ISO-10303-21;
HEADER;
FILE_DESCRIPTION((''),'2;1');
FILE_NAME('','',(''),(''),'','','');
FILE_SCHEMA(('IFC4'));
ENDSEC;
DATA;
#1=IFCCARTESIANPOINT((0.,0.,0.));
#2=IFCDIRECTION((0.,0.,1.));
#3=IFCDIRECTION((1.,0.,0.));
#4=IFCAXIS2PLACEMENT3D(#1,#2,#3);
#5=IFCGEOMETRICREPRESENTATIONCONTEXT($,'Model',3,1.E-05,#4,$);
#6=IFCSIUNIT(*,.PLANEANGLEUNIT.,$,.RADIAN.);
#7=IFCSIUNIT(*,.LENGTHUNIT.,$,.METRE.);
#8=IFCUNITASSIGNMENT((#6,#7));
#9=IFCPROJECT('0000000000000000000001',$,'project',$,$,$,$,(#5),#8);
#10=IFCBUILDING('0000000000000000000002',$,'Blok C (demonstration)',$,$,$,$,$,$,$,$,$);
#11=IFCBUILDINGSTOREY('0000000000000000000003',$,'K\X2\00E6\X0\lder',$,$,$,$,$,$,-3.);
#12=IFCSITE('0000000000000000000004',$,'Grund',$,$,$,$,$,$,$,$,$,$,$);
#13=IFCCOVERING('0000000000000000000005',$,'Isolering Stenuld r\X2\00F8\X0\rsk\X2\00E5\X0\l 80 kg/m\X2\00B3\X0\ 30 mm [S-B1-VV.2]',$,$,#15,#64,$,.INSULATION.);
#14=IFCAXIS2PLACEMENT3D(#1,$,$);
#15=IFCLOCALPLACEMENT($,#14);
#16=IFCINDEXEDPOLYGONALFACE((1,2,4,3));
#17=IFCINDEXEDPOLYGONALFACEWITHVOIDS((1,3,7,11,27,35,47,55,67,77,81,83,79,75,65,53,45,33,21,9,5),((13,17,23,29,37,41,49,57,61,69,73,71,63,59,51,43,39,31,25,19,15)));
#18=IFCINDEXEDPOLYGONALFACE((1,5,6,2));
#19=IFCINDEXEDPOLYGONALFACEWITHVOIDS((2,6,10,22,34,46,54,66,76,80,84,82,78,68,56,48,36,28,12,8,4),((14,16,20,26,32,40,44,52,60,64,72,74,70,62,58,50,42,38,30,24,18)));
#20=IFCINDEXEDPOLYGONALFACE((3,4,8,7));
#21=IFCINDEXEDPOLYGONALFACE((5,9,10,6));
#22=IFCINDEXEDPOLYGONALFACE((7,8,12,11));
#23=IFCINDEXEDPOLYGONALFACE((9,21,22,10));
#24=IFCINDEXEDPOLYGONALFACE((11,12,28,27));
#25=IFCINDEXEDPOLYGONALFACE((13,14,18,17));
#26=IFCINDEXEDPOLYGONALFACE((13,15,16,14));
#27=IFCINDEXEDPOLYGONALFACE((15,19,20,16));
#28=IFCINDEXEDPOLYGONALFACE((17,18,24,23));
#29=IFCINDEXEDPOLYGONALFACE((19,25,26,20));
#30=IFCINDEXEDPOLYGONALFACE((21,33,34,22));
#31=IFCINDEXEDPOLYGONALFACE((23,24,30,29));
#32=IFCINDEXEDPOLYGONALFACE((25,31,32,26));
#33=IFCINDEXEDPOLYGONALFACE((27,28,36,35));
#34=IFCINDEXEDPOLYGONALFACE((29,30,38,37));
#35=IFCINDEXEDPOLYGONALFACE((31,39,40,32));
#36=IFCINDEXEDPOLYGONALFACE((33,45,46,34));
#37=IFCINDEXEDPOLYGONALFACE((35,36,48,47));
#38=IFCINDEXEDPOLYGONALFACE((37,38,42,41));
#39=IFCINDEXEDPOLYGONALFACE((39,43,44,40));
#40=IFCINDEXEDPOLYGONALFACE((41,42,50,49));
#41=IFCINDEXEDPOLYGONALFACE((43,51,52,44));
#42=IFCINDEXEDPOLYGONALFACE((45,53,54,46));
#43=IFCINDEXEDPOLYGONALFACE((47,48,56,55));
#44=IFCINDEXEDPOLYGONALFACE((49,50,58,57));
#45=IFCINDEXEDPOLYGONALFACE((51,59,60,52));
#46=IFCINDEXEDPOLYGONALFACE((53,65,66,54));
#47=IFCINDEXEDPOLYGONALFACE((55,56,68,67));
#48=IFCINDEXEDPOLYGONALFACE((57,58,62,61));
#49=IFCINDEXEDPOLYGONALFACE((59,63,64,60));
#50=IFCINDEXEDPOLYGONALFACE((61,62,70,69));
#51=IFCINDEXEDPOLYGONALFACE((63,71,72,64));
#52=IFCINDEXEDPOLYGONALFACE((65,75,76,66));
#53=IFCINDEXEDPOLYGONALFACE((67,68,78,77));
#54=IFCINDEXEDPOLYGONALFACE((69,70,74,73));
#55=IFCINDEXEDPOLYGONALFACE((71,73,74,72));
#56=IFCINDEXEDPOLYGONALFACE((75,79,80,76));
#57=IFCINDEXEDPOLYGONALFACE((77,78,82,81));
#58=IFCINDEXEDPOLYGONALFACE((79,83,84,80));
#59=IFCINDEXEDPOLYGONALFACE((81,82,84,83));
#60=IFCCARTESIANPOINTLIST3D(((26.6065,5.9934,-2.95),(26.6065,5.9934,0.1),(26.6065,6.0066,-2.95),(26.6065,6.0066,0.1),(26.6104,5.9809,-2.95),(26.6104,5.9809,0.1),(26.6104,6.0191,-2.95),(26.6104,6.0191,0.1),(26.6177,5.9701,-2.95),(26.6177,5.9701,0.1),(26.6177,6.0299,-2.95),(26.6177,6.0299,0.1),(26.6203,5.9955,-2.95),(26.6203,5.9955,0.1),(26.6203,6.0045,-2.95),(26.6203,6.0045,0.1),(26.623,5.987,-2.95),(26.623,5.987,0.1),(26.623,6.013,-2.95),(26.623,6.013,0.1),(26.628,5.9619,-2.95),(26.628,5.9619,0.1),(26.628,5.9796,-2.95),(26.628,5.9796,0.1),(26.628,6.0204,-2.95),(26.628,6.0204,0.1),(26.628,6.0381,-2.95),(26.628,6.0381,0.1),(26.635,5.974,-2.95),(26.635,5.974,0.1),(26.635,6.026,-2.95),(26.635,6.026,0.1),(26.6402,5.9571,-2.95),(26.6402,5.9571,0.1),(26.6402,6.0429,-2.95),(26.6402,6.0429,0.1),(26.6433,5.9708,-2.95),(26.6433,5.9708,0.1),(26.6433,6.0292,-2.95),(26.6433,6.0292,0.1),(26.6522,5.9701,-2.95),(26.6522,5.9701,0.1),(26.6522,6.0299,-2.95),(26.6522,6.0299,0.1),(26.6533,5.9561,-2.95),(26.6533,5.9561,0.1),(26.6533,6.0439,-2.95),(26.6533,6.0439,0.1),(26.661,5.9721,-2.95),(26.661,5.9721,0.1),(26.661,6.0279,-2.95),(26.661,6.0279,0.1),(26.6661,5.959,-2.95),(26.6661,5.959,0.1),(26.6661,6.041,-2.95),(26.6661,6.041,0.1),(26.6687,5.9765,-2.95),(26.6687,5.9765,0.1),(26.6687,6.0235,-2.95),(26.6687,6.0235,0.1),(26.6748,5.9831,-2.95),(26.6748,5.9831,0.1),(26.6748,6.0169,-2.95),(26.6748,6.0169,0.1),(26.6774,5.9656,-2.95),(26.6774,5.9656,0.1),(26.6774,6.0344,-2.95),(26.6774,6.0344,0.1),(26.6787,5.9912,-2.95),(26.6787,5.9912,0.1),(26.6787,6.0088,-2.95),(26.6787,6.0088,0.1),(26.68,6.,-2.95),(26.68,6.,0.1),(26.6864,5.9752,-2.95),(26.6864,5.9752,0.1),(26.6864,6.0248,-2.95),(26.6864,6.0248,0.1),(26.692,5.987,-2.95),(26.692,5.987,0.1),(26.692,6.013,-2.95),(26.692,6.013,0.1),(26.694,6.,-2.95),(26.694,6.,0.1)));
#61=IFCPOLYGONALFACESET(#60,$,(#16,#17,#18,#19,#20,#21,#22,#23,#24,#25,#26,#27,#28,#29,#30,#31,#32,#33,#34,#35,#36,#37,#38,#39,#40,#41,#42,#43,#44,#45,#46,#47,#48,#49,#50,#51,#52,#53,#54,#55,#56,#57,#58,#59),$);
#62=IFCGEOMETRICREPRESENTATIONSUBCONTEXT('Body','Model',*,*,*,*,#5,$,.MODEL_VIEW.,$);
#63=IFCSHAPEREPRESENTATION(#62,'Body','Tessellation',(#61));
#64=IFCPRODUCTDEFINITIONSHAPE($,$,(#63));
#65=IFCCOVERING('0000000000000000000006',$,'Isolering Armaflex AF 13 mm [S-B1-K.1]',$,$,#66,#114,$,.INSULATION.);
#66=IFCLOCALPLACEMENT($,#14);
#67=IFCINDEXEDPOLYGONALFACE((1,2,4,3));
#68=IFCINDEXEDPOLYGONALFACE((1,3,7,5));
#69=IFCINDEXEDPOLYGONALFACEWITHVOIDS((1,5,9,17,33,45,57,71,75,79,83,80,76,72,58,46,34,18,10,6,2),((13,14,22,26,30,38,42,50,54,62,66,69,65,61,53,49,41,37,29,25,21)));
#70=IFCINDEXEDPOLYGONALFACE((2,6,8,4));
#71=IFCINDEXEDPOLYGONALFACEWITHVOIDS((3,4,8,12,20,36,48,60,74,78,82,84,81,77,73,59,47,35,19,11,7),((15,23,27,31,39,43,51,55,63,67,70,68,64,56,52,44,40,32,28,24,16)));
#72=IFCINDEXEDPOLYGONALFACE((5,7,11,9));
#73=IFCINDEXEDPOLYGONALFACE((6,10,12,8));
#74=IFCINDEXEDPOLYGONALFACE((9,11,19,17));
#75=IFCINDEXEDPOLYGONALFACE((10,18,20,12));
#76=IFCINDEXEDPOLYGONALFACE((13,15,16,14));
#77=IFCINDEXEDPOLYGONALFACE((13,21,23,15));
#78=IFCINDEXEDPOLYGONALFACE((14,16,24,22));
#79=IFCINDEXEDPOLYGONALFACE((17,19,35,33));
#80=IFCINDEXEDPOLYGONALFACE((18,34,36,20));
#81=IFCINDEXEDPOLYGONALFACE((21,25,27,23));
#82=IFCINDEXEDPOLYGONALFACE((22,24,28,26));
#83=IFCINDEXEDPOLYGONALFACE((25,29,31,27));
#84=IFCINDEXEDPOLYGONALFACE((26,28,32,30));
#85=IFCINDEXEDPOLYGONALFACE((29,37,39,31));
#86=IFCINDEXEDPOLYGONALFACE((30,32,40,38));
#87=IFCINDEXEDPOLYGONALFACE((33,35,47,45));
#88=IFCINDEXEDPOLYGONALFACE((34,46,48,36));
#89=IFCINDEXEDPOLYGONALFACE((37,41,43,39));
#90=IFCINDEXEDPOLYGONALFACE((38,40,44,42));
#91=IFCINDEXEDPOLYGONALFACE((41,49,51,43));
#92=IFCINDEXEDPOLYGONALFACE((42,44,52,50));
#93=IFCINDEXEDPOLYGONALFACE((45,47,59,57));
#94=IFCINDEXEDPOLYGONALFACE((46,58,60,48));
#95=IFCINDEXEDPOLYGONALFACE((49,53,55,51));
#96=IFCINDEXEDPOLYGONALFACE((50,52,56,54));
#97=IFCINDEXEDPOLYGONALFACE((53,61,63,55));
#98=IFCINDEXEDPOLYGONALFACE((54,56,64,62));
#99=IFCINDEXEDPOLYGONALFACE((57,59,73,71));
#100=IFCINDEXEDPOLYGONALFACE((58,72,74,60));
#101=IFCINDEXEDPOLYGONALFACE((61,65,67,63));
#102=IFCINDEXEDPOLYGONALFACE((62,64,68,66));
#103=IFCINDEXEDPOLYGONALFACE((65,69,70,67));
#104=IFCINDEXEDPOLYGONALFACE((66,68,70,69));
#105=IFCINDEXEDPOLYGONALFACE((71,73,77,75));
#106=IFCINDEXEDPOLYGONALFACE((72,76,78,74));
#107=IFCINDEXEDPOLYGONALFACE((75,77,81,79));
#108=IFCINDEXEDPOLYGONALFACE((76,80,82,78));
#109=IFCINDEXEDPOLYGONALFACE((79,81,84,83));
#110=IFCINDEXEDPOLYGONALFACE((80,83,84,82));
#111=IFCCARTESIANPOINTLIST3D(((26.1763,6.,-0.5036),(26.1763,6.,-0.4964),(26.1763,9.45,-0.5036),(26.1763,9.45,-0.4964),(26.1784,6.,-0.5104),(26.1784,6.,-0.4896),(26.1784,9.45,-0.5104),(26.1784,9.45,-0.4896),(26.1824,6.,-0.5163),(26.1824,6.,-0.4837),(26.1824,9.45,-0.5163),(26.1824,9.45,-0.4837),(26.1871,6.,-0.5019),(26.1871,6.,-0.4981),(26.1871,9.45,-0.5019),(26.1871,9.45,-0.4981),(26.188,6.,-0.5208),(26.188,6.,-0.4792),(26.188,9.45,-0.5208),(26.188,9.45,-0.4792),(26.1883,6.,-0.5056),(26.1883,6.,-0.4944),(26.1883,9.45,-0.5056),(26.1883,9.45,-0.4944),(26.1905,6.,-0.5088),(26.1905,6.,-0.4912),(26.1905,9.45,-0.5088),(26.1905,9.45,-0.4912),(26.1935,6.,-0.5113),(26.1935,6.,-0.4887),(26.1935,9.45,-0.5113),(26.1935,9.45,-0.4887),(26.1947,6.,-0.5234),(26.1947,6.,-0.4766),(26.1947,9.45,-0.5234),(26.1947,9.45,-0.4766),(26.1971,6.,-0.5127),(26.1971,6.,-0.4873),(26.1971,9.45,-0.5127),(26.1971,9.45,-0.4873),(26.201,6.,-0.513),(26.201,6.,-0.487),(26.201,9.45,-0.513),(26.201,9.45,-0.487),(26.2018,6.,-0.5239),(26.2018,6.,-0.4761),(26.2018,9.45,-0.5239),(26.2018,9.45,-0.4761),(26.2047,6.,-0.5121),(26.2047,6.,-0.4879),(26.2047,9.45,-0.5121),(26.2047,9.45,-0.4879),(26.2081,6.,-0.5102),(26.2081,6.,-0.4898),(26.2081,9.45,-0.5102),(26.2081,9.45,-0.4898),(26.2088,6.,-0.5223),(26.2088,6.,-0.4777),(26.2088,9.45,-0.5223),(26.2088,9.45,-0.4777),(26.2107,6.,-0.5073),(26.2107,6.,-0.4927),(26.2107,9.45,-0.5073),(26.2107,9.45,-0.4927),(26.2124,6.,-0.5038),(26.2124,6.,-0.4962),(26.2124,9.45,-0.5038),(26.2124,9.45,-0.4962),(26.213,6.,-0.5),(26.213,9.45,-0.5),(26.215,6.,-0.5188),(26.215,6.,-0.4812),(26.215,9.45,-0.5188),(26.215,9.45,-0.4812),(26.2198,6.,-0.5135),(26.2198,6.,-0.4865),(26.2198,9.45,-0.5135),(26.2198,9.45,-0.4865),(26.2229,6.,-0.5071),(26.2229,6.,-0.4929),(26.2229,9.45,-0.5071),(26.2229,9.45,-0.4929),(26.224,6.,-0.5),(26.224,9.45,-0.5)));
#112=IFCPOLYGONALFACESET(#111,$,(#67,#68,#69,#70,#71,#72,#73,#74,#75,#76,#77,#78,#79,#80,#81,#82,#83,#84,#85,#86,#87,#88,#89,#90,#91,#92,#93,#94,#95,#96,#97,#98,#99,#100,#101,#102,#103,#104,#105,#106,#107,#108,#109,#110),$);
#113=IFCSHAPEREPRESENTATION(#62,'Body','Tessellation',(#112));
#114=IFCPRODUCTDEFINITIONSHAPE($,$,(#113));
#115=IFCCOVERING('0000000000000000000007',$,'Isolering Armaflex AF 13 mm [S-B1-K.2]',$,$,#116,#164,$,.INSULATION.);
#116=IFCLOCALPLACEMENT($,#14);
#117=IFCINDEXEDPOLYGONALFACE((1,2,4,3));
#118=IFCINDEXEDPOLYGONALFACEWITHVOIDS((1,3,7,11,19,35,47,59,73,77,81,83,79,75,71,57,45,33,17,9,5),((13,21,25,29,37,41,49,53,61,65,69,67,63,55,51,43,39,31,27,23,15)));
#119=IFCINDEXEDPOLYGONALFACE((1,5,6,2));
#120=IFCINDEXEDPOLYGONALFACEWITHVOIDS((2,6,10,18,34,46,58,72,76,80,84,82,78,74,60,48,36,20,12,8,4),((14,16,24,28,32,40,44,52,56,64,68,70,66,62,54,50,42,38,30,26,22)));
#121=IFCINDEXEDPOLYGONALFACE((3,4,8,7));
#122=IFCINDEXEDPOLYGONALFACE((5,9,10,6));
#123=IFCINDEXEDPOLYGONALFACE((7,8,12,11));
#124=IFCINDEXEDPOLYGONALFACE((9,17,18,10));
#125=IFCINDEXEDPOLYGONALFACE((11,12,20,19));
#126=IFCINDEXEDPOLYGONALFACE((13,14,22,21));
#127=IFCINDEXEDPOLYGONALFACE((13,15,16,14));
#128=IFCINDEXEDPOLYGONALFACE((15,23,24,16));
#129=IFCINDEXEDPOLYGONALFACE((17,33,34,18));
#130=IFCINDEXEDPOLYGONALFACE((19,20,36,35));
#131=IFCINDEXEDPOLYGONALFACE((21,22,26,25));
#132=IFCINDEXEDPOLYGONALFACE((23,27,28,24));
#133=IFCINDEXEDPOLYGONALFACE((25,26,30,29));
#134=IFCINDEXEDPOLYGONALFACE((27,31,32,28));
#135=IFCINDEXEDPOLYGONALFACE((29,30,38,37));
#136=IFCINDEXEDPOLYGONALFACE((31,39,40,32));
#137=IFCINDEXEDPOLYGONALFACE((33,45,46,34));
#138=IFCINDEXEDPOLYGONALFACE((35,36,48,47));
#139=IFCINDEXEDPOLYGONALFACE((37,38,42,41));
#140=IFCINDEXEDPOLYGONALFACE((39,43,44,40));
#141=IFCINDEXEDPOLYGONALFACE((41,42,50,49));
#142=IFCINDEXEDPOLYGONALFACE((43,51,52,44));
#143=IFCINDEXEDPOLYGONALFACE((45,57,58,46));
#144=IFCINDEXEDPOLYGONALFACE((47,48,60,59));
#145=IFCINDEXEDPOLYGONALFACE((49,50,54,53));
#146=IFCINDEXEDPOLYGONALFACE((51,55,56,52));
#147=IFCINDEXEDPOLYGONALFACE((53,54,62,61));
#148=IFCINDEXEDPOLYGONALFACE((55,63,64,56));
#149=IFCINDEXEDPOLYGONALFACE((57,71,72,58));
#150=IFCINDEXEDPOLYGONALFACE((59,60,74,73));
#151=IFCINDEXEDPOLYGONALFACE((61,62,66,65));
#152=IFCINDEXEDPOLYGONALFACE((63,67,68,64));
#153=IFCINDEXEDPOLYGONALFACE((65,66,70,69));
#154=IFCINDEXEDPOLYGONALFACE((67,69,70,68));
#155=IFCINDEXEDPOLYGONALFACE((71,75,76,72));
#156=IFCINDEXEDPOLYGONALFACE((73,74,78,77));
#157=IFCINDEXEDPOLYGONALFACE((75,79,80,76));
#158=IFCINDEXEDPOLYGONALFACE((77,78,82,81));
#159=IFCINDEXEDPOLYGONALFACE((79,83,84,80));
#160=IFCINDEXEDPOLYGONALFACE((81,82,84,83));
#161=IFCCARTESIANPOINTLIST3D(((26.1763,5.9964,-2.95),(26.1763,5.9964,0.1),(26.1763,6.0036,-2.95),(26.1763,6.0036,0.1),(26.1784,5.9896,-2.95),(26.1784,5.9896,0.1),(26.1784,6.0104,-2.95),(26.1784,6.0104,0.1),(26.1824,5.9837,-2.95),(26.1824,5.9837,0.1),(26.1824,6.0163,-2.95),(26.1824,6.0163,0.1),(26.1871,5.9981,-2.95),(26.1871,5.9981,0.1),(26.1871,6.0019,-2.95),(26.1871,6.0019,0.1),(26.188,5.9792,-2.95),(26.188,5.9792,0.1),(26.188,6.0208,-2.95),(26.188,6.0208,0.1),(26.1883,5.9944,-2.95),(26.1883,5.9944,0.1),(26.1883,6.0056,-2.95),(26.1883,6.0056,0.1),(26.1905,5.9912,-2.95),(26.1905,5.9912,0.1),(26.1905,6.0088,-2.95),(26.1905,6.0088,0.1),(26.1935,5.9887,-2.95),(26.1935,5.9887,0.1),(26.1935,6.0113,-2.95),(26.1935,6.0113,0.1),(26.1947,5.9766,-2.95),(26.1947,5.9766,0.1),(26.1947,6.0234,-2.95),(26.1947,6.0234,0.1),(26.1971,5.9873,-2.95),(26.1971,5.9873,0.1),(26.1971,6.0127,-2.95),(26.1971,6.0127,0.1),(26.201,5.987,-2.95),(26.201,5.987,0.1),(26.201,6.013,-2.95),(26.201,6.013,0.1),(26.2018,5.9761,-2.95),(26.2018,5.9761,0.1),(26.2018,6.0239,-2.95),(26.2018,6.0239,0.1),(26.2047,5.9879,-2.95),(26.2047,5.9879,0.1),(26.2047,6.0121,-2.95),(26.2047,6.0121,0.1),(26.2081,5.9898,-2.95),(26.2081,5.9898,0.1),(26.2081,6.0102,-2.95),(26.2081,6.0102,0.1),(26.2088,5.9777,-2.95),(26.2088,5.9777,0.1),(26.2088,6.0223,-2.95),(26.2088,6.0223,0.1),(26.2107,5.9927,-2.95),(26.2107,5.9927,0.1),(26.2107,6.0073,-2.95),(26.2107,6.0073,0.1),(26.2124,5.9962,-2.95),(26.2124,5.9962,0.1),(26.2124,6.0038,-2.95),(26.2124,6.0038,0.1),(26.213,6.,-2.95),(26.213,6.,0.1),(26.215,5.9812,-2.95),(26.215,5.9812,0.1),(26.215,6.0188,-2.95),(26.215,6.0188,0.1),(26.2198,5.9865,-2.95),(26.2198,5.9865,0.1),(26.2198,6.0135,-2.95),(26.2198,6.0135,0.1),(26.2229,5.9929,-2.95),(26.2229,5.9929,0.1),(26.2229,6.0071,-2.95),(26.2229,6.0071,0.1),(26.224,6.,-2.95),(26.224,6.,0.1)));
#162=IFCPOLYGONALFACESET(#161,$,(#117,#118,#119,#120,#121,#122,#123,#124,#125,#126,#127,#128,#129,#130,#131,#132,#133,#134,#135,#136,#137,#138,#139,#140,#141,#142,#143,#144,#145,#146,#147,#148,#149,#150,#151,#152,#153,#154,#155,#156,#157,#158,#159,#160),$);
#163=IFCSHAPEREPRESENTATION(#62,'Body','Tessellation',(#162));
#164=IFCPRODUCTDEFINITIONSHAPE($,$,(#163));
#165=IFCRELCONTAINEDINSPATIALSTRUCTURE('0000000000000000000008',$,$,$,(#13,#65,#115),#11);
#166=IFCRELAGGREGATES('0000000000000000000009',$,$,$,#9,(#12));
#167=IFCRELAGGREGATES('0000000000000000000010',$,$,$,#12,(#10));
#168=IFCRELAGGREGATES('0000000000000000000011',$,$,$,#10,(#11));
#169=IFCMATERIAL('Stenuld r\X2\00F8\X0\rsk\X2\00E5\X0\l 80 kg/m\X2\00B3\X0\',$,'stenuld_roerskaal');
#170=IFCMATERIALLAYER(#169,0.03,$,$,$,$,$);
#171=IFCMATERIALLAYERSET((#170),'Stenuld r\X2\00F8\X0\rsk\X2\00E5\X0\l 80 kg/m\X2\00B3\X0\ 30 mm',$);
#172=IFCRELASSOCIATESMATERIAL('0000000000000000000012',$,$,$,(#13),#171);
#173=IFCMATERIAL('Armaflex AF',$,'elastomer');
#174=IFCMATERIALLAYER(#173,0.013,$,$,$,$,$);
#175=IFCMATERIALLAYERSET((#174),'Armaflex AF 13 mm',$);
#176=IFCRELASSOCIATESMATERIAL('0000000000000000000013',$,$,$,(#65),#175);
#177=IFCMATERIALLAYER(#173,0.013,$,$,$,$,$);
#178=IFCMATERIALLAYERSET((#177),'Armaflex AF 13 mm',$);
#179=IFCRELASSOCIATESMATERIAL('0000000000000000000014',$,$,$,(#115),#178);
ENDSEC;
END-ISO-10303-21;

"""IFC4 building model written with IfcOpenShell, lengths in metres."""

from ifc_helpers import new_model, si_unit, frame, origin_with_axes, place, context, subcontext, project, spatial, hollow_circle, extrude, material, layer, layer_set, element, save


model = new_model("IFC4")

# Units and contexts
model_context = context("Model", 3, precision=1e-05, world=origin_with_axes())
body_context = subcontext(model_context, "Body", "Model", "MODEL_VIEW")
ifc_project = project(units=[si_unit("PLANEANGLEUNIT", "RADIAN"), si_unit("LENGTHUNIT", "METRE")], contexts=[model_context])

# Site, building, storey
site = spatial("IfcSite", under=ifc_project, Name="Grund")
building = spatial("IfcBuilding", under=site, Name="Blok C (demonstration)")
storey = spatial("IfcBuildingStorey", under=building, Name="Kælder", Elevation=-3.0)

# Coverings
ifc_material_1 = material(Name="Stenuld rørskål 80 kg/m³", Category="stenuld_roerskaal")
ifc_layer_1 = layer(ifc_material_1, 0.03)
ifc_layer_set_1 = layer_set([ifc_layer_1], Name="Stenuld rørskål 80 kg/m³ 30 mm")
covering_1_placement = place(None, origin_with_axes())
element("IfcCovering", 1, at=covering_1_placement, inside=storey, material=ifc_layer_set_1, Name="Isolering Stenuld rørskål 80 kg/m³ 30 mm [S-B1-VV.2]", PredefinedType="INSULATION", context=body_context, shape_type="SweptSolid", body=[
    extrude(hollow_circle(Radius=0.044, WallThickness=0.014), frame((26.65, 6.0, -2.95), z_axis=(0.0, 0.0, 1.0), x_axis=(1.0, 0.0, 0.0)), (0.0, 0.0, 1.0), 3.05),
])
ifc_material_2 = material(Name="Armaflex AF", Category="elastomer")
ifc_layer_2 = layer(ifc_material_2, 0.013)
ifc_layer_set_2 = layer_set([ifc_layer_2], Name="Armaflex AF 13 mm")
covering_2_placement = place(None, origin_with_axes())
element("IfcCovering", 2, at=covering_2_placement, inside=storey, material=ifc_layer_set_2, Name="Isolering Armaflex AF 13 mm [S-B1-K.1]", PredefinedType="INSULATION", context=body_context, shape_type="SweptSolid", body=[
    extrude(hollow_circle(Radius=0.024, WallThickness=0.011), frame((26.2, 9.45, -0.5), z_axis=(0.0, -1.0, 0.0), x_axis=(1.0, 0.0, 0.0)), (0.0, 0.0, 1.0), 3.45),
])
ifc_layer_3 = layer(ifc_material_2, 0.013)
ifc_layer_set_3 = layer_set([ifc_layer_3], Name="Armaflex AF 13 mm")
covering_3_placement = place(None, origin_with_axes())
element("IfcCovering", 3, at=covering_3_placement, inside=storey, material=ifc_layer_set_3, Name="Isolering Armaflex AF 13 mm [S-B1-K.2]", PredefinedType="INSULATION", context=body_context, shape_type="SweptSolid", body=[
    extrude(hollow_circle(Radius=0.024, WallThickness=0.011), frame((26.2, 6.0, -2.95), z_axis=(0.0, 0.0, 1.0), x_axis=(1.0, 0.0, 0.0)), (0.0, 0.0, 1.0), 3.05),
])

save(model, "model.ifc")
